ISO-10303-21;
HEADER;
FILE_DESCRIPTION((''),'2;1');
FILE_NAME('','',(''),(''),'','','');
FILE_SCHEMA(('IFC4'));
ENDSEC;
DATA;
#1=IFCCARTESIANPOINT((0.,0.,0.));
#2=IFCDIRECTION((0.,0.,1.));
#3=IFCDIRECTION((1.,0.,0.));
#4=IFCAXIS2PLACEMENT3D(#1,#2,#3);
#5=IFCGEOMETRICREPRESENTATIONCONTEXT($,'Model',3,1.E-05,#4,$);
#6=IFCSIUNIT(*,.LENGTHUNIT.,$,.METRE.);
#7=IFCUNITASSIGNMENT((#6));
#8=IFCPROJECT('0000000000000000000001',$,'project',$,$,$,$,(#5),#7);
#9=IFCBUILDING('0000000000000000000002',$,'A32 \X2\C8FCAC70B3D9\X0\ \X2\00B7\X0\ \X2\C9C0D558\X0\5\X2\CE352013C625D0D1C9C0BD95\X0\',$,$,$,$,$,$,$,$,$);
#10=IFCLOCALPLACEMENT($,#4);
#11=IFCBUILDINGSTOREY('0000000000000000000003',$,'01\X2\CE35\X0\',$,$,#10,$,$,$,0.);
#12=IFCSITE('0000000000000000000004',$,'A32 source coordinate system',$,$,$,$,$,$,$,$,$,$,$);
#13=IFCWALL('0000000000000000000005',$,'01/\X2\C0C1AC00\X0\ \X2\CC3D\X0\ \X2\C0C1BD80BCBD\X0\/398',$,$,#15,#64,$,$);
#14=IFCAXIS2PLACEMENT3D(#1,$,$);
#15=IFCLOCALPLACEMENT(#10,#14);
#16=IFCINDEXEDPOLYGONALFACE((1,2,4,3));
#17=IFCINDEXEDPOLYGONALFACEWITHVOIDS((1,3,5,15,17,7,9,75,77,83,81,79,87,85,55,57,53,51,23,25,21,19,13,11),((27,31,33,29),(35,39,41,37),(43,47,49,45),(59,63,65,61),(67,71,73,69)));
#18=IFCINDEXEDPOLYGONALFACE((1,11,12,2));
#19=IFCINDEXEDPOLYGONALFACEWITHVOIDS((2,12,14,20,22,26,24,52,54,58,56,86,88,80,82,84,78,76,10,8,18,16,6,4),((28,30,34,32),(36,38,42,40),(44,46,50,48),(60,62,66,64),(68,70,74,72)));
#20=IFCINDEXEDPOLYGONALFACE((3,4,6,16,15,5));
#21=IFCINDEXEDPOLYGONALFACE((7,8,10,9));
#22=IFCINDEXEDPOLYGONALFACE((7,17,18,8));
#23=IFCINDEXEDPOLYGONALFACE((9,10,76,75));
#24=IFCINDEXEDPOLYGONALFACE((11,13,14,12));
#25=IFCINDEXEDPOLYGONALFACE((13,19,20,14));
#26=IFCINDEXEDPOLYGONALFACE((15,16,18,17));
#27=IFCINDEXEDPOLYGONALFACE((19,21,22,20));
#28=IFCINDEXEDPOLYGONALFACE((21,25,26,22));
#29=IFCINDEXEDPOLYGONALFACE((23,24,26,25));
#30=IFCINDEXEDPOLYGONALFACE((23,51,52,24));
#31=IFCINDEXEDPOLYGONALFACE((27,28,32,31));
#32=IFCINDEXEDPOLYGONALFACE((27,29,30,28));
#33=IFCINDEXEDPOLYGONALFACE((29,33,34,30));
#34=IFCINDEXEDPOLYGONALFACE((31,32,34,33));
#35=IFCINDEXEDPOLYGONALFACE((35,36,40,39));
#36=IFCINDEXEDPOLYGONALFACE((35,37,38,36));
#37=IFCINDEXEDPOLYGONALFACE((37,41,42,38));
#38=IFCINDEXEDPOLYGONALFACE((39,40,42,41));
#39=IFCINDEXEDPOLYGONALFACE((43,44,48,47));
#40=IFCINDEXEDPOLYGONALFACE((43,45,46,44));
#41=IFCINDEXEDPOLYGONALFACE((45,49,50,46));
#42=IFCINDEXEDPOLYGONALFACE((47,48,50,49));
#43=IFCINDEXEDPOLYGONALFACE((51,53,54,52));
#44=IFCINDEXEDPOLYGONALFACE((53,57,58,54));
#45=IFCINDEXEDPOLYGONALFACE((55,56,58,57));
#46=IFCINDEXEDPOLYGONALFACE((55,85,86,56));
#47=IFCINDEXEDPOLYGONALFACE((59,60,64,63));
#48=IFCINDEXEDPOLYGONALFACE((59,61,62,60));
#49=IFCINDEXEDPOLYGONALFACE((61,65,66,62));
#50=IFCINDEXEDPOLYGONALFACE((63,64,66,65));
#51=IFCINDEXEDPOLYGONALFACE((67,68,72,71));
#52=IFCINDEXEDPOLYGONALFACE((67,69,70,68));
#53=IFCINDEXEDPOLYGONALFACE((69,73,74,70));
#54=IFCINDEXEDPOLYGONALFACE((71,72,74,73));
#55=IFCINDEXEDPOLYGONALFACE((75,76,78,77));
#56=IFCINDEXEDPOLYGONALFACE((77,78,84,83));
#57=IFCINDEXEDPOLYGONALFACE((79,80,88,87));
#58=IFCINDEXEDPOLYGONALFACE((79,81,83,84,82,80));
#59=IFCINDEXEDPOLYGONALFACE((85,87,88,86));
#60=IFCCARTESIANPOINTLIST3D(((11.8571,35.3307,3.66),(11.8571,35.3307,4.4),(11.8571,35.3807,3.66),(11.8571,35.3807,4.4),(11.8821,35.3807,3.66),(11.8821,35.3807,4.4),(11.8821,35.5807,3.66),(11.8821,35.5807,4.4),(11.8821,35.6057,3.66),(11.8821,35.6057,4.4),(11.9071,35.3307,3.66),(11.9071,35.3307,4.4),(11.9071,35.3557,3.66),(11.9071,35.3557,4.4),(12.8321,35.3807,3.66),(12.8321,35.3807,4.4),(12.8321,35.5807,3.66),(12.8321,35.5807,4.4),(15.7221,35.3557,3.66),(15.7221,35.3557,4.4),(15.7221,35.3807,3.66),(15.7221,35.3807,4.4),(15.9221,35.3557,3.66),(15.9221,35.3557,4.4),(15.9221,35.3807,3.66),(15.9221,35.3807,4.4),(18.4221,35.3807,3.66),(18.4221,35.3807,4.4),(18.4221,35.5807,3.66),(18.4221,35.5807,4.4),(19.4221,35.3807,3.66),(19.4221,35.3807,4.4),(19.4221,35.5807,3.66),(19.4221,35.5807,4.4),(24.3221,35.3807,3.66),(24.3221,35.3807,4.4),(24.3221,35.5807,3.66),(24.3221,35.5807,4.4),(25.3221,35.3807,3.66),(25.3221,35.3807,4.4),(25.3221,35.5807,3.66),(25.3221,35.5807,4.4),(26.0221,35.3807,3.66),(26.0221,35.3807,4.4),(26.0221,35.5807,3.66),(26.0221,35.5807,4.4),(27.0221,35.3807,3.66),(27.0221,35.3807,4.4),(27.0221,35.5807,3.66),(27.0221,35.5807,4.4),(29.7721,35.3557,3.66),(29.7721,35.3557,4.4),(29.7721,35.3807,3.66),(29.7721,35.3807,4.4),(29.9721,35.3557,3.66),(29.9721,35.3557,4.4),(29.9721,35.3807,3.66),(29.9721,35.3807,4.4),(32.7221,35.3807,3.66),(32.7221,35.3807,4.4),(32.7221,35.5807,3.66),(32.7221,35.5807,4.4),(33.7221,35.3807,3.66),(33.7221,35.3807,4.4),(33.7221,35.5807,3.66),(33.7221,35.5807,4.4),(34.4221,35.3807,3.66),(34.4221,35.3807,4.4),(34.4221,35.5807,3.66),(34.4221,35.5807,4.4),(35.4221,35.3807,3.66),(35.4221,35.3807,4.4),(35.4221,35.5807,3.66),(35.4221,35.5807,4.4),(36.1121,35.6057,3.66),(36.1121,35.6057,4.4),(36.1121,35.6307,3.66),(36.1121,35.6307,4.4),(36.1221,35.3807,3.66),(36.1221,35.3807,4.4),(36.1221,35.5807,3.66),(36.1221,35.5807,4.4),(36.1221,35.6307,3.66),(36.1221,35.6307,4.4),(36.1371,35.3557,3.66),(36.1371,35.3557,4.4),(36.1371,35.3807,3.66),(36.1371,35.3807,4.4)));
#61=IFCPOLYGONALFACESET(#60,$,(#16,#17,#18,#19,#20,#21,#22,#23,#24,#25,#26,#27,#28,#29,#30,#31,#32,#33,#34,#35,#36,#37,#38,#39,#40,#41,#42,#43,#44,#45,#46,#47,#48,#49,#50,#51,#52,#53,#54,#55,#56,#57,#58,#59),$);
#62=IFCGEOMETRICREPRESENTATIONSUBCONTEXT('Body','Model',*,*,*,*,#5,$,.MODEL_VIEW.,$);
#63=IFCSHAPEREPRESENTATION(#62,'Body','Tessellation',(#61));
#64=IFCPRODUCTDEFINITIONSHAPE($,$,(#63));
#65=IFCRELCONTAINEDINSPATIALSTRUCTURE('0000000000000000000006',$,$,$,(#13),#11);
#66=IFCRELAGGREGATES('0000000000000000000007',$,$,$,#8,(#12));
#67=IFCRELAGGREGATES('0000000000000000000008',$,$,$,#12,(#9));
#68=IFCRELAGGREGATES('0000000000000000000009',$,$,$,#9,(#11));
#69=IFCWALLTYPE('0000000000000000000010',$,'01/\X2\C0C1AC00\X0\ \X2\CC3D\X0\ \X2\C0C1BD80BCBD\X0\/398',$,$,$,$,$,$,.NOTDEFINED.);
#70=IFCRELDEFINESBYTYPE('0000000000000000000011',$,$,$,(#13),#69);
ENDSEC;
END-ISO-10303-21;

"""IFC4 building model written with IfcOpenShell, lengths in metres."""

from ifc_helpers import new_model, si_unit, frame, origin, origin_with_axes, place, context, subcontext, project, spatial, polyline, outline, extrude, source, transform, mapped, type_object, type_shapes, element, save


model = new_model("IFC4")

# Units and contexts
model_context = context("Model", 3, precision=1e-05, world=origin_with_axes())
body_context = subcontext(model_context, "Body", "Model", "MODEL_VIEW")
ifc_project = project(units=[si_unit("LENGTHUNIT", "METRE")], contexts=[model_context])

# Site, building, storey
site = spatial("IfcSite", under=ifc_project, Name="A32 source coordinate system")
building = spatial("IfcBuilding", under=site, Name="A32 주거동 · 지하5층–옥탑지붕")
storey_placement = place(None, origin_with_axes())
storey = spatial("IfcBuildingStorey", under=building, at=storey_placement, Name="01층", Elevation=0.0)

# Wall
wall_type_1 = type_object("IfcWallType", Name="01/상가 창 상부벽/398", PredefinedType="NOTDEFINED")
shared_shape_1 = source(origin(), body_context, "Body", "SweptSolid", [
    extrude(outline(polyline([(11.8571, 35.3807), (11.8821, 35.3807), (11.8821, 35.3807), (12.8321, 35.3807), (12.8321, 35.5807), (11.8821, 35.5807), (11.8821, 35.6057), (36.1121, 35.6057), (36.1121, 35.6307), (36.1221, 35.6307), (36.1221, 35.5807), (36.1221, 35.3807), (36.1371, 35.3807), (36.1371, 35.3557), (29.9721, 35.3557), (29.9721, 35.3807), (29.7721, 35.3807), (29.7721, 35.3557), (15.9221, 35.3557), (15.9221, 35.3807), (15.7221, 35.3807), (15.7221, 35.3557), (11.9071, 35.3557), (11.9071, 35.3307), (11.8571, 35.3307), (11.8571, 35.3807)]), holes=[polyline([(35.4221, 35.5807), (34.4221, 35.5807), (34.4221, 35.3807), (35.4221, 35.3807), (35.4221, 35.5807)]), polyline([(33.7221, 35.3807), (33.7221, 35.5807), (32.7221, 35.5807), (32.7221, 35.3807), (33.7221, 35.3807)]), polyline([(27.0221, 35.5807), (26.0221, 35.5807), (26.0221, 35.3807), (27.0221, 35.3807), (27.0221, 35.5807)]), polyline([(25.3221, 35.3807), (25.3221, 35.5807), (24.3221, 35.5807), (24.3221, 35.3807), (25.3221, 35.3807)]), polyline([(19.4221, 35.3807), (19.4221, 35.5807), (18.4221, 35.5807), (18.4221, 35.3807), (19.4221, 35.3807)])]), frame((0.0, 0.0, 3.66)), (0.0, 0.0, 1.0), 0.74),
])
type_shapes(wall_type_1, [shared_shape_1])
wall_1_placement = place(storey_placement, origin_with_axes())
element("IfcWall", 1, at=wall_1_placement, inside=storey, type_object=wall_type_1, Name="01/상가 창 상부벽/398", context=body_context, shape_type="MappedRepresentation", body=[
    mapped(shared_shape_1, transform((0.0, 0.0, 0.0), scale=1.0)),
])

save(model, "model.ifc")
